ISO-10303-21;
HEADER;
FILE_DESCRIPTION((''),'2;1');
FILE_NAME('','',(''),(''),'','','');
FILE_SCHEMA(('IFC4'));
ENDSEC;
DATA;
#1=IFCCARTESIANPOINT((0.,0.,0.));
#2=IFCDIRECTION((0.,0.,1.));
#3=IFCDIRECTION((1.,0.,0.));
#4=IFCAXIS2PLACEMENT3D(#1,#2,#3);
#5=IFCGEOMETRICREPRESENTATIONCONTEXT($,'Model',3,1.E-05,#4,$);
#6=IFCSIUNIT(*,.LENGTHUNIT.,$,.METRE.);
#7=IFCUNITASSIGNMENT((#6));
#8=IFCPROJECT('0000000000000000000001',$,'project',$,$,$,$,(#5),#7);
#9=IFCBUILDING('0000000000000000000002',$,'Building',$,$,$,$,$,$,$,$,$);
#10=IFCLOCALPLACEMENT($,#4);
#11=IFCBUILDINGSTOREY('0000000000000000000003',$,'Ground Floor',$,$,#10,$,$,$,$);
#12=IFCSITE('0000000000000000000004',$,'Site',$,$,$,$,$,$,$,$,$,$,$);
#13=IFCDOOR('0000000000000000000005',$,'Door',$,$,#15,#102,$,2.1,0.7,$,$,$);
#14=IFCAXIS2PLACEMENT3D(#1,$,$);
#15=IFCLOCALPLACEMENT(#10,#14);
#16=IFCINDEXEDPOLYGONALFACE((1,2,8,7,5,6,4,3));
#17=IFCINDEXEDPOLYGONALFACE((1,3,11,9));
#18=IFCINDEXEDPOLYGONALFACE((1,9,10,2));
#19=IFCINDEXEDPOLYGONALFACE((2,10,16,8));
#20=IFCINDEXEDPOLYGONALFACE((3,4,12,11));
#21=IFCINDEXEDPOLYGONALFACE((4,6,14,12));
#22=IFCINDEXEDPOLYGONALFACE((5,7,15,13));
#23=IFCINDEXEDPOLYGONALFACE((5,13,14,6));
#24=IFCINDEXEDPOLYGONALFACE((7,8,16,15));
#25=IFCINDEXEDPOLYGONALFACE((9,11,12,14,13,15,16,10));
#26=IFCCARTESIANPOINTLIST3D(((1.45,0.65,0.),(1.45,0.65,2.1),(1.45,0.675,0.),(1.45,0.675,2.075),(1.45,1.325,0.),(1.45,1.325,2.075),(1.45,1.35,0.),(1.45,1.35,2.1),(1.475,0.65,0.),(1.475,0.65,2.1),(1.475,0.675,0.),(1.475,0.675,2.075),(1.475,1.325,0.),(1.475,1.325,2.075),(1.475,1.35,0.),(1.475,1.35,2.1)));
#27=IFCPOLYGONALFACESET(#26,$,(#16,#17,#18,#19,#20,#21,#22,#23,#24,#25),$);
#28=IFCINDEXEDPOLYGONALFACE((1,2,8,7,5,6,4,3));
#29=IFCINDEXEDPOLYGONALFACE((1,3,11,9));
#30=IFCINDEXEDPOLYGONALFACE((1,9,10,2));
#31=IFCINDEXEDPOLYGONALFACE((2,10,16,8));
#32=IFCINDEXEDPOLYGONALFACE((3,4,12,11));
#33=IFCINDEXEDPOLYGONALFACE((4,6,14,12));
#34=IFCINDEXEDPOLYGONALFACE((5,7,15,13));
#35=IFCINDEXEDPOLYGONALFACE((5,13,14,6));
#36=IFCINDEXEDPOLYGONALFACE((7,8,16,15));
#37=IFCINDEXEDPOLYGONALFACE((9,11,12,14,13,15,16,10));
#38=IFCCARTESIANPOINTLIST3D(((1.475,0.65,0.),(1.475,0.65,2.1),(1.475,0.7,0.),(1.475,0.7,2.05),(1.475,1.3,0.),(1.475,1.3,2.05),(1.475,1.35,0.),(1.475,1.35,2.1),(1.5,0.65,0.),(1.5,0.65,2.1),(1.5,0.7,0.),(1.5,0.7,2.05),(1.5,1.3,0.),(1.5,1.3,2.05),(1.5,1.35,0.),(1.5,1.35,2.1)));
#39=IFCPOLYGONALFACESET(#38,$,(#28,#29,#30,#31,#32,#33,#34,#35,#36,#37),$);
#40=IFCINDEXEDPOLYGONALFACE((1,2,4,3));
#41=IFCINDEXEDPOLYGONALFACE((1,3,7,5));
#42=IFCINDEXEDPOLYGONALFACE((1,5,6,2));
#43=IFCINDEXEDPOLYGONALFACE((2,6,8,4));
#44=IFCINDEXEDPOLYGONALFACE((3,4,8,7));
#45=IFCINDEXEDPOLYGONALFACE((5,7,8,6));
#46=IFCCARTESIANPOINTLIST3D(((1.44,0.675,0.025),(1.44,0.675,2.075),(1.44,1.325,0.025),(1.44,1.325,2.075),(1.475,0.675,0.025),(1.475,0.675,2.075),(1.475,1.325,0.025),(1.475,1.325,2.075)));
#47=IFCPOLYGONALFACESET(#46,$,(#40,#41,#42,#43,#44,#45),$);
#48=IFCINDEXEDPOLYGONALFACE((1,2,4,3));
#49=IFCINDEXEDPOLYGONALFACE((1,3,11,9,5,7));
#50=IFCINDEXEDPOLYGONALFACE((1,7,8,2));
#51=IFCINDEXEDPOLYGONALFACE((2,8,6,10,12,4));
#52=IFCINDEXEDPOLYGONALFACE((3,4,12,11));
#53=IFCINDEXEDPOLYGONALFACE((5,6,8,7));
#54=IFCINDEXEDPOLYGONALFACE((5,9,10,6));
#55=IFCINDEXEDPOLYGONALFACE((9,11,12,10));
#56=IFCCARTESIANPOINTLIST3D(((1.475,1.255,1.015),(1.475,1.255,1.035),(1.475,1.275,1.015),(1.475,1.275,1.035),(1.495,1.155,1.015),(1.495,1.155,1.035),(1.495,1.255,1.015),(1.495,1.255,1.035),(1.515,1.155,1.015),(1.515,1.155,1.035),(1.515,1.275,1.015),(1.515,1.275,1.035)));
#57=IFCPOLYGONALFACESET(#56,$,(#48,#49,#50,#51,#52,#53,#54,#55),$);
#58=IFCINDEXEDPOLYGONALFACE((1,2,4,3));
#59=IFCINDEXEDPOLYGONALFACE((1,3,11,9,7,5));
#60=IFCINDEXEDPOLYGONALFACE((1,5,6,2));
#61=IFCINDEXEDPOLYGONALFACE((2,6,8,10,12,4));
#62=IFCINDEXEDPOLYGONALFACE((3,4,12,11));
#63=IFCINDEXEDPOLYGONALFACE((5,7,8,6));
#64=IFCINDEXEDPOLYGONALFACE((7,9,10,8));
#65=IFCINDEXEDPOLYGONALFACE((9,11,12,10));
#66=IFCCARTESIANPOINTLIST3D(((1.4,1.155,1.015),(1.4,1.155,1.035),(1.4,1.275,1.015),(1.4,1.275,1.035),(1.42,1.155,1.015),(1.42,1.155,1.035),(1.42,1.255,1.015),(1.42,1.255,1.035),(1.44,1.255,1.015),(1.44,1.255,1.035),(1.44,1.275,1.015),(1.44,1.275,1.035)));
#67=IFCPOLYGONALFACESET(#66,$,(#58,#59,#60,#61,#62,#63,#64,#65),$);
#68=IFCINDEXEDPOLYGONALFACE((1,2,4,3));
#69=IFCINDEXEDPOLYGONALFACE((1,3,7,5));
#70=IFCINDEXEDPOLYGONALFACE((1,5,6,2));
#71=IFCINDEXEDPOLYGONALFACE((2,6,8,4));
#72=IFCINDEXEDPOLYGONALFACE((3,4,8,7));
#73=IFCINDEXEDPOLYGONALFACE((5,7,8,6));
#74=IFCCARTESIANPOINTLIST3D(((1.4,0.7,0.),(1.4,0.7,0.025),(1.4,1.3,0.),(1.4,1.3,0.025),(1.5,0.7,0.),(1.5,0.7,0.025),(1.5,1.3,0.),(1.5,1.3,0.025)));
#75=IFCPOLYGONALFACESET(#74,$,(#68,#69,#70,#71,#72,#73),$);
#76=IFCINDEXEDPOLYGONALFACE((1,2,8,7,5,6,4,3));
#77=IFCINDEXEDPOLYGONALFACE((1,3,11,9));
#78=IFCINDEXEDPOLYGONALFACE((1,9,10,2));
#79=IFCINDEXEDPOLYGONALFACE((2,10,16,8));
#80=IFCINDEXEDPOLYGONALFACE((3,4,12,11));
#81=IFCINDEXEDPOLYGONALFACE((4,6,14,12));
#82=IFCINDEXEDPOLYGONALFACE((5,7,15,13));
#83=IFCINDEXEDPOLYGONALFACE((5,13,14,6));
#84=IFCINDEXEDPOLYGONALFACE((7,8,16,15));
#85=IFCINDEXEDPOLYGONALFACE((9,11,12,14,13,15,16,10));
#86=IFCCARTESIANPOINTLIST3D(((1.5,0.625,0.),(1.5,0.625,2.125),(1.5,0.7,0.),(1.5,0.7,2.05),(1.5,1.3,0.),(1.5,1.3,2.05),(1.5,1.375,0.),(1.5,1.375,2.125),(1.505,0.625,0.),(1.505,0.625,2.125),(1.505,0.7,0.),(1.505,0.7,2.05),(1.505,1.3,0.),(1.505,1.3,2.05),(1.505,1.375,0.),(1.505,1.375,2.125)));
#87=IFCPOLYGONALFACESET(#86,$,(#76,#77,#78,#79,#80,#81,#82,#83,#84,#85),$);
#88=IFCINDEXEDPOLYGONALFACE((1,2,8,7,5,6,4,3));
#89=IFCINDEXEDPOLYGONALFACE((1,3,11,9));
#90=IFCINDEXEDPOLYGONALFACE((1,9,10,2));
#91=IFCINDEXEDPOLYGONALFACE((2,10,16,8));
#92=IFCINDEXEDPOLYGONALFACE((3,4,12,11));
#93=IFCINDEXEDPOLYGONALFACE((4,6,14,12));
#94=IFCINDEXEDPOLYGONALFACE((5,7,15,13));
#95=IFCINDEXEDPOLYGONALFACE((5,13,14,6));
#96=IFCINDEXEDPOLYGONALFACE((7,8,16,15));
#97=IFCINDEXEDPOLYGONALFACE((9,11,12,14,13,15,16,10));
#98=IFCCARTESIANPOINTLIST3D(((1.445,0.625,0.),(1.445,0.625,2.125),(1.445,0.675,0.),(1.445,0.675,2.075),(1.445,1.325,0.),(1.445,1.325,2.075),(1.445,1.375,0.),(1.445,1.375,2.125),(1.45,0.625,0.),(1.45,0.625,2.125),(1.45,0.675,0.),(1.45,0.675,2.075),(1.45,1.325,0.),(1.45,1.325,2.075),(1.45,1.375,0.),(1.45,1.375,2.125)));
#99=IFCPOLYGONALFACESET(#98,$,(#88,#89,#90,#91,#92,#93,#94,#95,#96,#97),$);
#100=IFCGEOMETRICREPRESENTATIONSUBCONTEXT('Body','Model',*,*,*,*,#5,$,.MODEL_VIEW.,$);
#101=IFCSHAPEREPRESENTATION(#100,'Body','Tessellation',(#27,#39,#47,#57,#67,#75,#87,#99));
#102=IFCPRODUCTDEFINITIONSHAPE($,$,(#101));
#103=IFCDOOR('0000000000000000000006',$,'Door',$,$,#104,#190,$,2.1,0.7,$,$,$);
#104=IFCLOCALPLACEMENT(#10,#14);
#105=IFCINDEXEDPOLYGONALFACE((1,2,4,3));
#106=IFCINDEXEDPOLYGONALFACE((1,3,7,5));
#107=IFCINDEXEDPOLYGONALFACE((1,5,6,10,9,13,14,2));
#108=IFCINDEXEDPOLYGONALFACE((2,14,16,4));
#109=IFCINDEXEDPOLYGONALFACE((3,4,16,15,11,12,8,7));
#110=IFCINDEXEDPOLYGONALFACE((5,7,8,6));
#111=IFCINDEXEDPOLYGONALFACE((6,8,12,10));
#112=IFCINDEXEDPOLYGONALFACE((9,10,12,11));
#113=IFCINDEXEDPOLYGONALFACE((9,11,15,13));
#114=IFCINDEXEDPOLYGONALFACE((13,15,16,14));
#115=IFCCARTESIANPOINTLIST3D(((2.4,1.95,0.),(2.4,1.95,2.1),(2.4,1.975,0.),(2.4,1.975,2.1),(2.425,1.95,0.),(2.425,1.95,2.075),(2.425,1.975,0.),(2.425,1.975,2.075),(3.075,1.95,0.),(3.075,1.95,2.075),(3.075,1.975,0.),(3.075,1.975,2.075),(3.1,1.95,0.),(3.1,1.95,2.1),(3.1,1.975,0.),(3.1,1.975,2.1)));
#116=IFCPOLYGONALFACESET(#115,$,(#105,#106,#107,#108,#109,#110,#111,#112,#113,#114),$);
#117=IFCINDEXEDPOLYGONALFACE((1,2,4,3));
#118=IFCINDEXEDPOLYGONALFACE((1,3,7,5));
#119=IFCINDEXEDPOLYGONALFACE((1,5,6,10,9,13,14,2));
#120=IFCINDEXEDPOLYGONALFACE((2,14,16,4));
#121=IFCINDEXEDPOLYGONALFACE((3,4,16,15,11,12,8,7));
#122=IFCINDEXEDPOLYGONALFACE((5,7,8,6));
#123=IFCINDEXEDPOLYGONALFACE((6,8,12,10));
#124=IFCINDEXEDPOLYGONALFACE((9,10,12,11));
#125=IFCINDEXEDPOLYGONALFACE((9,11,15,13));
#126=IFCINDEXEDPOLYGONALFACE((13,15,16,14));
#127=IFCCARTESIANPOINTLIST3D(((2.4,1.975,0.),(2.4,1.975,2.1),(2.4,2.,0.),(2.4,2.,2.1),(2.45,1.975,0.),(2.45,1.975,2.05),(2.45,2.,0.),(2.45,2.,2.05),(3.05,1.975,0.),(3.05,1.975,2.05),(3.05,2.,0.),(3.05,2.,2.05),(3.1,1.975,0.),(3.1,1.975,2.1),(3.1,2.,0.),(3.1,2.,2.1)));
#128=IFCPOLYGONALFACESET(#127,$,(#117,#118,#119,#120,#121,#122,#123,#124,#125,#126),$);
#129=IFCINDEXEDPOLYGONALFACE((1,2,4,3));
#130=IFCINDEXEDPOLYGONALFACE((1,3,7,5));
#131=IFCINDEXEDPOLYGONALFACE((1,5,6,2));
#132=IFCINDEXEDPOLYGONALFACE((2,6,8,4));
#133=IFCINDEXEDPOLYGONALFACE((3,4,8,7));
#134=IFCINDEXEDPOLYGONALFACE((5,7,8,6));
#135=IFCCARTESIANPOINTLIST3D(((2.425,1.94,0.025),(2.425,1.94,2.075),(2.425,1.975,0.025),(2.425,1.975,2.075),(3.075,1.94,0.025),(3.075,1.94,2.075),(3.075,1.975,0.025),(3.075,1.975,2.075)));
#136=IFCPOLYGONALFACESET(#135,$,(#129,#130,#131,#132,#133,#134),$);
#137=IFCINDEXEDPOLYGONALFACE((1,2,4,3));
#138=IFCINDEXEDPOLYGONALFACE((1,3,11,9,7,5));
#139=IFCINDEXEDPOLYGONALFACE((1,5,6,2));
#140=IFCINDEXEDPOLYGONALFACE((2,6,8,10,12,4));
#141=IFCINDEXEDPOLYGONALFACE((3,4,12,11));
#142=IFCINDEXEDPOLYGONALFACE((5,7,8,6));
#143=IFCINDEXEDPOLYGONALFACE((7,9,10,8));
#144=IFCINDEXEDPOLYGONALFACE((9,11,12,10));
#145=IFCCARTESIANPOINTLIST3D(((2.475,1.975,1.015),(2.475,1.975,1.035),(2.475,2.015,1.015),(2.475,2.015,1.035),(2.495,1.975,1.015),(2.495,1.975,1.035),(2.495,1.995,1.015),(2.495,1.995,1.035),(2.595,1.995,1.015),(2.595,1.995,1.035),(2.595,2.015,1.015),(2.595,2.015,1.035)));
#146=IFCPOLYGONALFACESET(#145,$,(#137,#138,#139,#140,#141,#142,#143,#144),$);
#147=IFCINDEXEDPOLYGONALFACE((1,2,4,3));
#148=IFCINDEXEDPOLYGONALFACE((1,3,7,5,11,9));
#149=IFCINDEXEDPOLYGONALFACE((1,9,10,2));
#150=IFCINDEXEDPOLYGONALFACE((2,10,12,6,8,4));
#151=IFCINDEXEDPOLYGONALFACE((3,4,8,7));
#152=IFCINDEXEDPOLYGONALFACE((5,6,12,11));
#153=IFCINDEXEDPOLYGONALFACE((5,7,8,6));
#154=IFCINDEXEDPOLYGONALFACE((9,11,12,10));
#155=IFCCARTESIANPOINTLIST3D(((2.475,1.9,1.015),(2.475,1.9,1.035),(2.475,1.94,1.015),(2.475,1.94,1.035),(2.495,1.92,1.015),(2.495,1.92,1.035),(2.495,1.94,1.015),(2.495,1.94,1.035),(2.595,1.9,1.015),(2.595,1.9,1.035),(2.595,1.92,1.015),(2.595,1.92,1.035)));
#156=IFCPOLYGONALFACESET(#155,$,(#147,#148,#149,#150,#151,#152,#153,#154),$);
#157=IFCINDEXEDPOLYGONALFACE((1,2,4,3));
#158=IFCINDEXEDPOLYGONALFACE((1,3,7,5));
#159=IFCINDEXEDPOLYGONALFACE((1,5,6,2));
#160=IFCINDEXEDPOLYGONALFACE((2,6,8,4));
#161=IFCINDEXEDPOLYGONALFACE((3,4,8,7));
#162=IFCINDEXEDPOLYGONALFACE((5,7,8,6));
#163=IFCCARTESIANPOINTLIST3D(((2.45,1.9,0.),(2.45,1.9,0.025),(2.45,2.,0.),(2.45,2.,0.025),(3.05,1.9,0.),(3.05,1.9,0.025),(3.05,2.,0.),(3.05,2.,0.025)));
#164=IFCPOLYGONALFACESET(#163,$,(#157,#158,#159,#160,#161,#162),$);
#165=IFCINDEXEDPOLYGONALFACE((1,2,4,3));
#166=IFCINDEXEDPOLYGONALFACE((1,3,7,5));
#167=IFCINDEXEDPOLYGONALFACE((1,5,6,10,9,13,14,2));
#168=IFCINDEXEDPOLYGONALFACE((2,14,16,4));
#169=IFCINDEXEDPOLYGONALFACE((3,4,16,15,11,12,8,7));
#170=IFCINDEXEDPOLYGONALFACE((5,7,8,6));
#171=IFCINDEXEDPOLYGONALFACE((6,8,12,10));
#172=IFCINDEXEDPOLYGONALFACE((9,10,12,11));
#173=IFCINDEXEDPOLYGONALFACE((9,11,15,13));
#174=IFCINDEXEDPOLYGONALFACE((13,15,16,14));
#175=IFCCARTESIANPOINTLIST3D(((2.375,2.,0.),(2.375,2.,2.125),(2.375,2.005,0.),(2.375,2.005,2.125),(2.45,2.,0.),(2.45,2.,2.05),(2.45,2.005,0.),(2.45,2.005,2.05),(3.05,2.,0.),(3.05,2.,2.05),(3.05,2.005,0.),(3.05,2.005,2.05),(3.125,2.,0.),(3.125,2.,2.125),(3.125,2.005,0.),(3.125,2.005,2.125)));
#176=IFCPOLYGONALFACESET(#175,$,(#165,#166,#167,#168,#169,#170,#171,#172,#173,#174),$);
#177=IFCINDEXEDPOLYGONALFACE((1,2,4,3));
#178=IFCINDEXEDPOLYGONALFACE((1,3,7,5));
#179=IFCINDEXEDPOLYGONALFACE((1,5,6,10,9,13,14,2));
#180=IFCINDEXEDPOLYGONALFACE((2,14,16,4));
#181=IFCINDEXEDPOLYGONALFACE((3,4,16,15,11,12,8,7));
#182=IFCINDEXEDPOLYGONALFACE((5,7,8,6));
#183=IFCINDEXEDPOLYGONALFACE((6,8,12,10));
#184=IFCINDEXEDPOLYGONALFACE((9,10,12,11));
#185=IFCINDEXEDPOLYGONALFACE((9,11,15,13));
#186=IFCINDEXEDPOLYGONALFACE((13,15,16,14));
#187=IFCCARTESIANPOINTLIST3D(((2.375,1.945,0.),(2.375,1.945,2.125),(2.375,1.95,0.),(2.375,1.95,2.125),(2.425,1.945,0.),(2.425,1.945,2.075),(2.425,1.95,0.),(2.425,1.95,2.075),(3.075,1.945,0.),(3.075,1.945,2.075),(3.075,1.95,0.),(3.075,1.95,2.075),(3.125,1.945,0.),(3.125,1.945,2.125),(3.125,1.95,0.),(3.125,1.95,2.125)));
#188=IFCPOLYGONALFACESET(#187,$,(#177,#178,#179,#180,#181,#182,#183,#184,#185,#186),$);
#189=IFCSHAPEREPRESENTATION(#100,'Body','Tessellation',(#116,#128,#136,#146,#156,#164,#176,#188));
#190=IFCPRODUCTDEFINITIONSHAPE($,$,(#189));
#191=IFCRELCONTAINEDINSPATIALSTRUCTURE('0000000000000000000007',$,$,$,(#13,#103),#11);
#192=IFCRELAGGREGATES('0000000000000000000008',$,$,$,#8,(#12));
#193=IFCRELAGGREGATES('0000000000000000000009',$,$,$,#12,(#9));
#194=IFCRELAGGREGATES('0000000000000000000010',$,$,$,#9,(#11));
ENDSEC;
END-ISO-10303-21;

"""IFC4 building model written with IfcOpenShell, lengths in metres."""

from ifc_helpers import new_model, si_unit, frame, origin_with_axes, place, context, subcontext, project, spatial, line, indexed_curve, outline, extrude, element, save


model = new_model("IFC4")

# Units and contexts
model_context = context("Model", 3, precision=1e-05, world=origin_with_axes())
body_context = subcontext(model_context, "Body", "Model", "MODEL_VIEW")
ifc_project = project(units=[si_unit("LENGTHUNIT", "METRE")], contexts=[model_context])

# Site, building, storey
site = spatial("IfcSite", under=ifc_project, Name="Site")
building = spatial("IfcBuilding", under=site, Name="Building")
storey_placement = place(None, origin_with_axes())
storey = spatial("IfcBuildingStorey", under=building, at=storey_placement, Name="Ground Floor")

# Doors
door_1_placement = place(storey_placement, frame((1.5, 0.65, 0.0), z_axis=(0.0, 0.0, 1.0), x_axis=(0.0, 1.0, 0.0)))
element("IfcDoor", 1, at=door_1_placement, inside=storey, Name="Door", OverallHeight=2.1, OverallWidth=0.7, context=body_context, shape_type="SweptSolid", body=[
    extrude(outline(indexed_curve([(0.0, 0.0), (0.0, 2.1), (0.7, 2.1), (0.7, 0.0), (0.675, 0.0), (0.675, 2.075), (0.025, 2.075), (0.025, 0.0)], segments=[line(1, 2, 3, 4, 5, 6, 7, 8, 1)])), frame((0.0, 0.025, 0.0), z_axis=(0.0, -1.0, 0.0), x_axis=(1.0, 0.0, 0.0)), (0.0, 0.0, -1.0), 0.025),
    extrude(outline(indexed_curve([(0.0, 0.0), (0.0, 2.1), (0.7, 2.1), (0.7, 0.0), (0.65, 0.0), (0.65, 2.05), (0.05, 2.05), (0.05, 0.0)], segments=[line(1, 2, 3, 4, 5, 6, 7, 8, 1)])), frame((0.0, 0.0, 0.0), z_axis=(0.0, -1.0, 0.0), x_axis=(1.0, 0.0, 0.0)), (0.0, 0.0, -1.0), 0.025),
    extrude(outline(indexed_curve([(0.0, 0.0), (0.65, 0.0), (0.65, 0.035), (0.0, 0.035)], segments=[line(1, 2, 3, 4, 1)])), frame((0.025, 0.025, 0.025), z_axis=(0.0, 0.0, 1.0), x_axis=(1.0, 0.0, 0.0)), (0.0, 0.0, 1.0), 2.05),
    extrude(outline(indexed_curve([(0.0, 0.0), (0.0, -0.04), (-0.12, -0.04), (-0.12, -0.02), (-0.02, -0.02), (-0.02, 0.0)], segments=[line(1, 2, 3, 4, 5, 6, 1)])), frame((0.625, 0.025, 1.015), z_axis=(0.0, 0.0, 1.0), x_axis=(1.0, 0.0, 0.0)), (0.0, 0.0, 1.0), 0.02),
    extrude(outline(indexed_curve([(0.0, 0.0), (0.0, 0.04), (-0.12, 0.04), (-0.12, 0.02), (-0.02, 0.02), (-0.02, 0.0)], segments=[line(1, 2, 3, 4, 5, 6, 1)])), frame((0.625, 0.06, 1.015), z_axis=(0.0, 0.0, 1.0), x_axis=(1.0, 0.0, 0.0)), (0.0, 0.0, 1.0), 0.02),
    extrude(outline(indexed_curve([(0.0, 0.0), (0.6, 0.0), (0.6, 0.1), (0.0, 0.1)], segments=[line(1, 2, 3, 4, 1)])), frame((0.05, 0.0, 0.0), z_axis=(0.0, 0.0, 1.0), x_axis=(1.0, 0.0, 0.0)), (0.0, 0.0, 1.0), 0.025),
    extrude(outline(indexed_curve([(0.0, 0.0), (0.0, 2.125), (0.75, 2.125), (0.75, 0.0), (0.675, 0.0), (0.675, 2.05), (0.075, 2.05), (0.075, 0.0)], segments=[line(1, 2, 3, 4, 5, 6, 7, 8, 1)])), frame((-0.025, -0.005, 0.0), z_axis=(0.0, -1.0, 0.0), x_axis=(1.0, 0.0, 0.0)), (0.0, 0.0, -1.0), 0.005),
    extrude(outline(indexed_curve([(0.0, 0.0), (0.0, 2.125), (0.75, 2.125), (0.75, 0.0), (0.7, 0.0), (0.7, 2.075), (0.05, 2.075), (0.05, 0.0)], segments=[line(1, 2, 3, 4, 5, 6, 7, 8, 1)])), frame((-0.025, 0.05, 0.0), z_axis=(0.0, -1.0, 0.0), x_axis=(1.0, 0.0, 0.0)), (0.0, 0.0, -1.0), 0.005),
])
door_2_placement = place(storey_placement, frame((3.1, 2.0, 0.0), z_axis=(0.0, 0.0, 1.0), x_axis=(-1.0, 0.0, 0.0)))
element("IfcDoor", 2, at=door_2_placement, inside=storey, Name="Door", OverallHeight=2.1, OverallWidth=0.7, context=body_context, shape_type="SweptSolid", body=[
    extrude(outline(indexed_curve([(0.0, 0.0), (0.0, 2.1), (0.7, 2.1), (0.7, 0.0), (0.675, 0.0), (0.675, 2.075), (0.025, 2.075), (0.025, 0.0)], segments=[line(1, 2, 3, 4, 5, 6, 7, 8, 1)])), frame((0.0, 0.025, 0.0), z_axis=(0.0, -1.0, 0.0), x_axis=(1.0, 0.0, 0.0)), (0.0, 0.0, -1.0), 0.025),
    extrude(outline(indexed_curve([(0.0, 0.0), (0.0, 2.1), (0.7, 2.1), (0.7, 0.0), (0.65, 0.0), (0.65, 2.05), (0.05, 2.05), (0.05, 0.0)], segments=[line(1, 2, 3, 4, 5, 6, 7, 8, 1)])), frame((0.0, 0.0, 0.0), z_axis=(0.0, -1.0, 0.0), x_axis=(1.0, 0.0, 0.0)), (0.0, 0.0, -1.0), 0.025),
    extrude(outline(indexed_curve([(0.0, 0.0), (0.65, 0.0), (0.65, 0.035), (0.0, 0.035)], segments=[line(1, 2, 3, 4, 1)])), frame((0.025, 0.025, 0.025), z_axis=(0.0, 0.0, 1.0), x_axis=(1.0, 0.0, 0.0)), (0.0, 0.0, 1.0), 2.05),
    extrude(outline(indexed_curve([(0.0, 0.0), (0.0, -0.04), (-0.12, -0.04), (-0.12, -0.02), (-0.02, -0.02), (-0.02, 0.0)], segments=[line(1, 2, 3, 4, 5, 6, 1)])), frame((0.625, 0.025, 1.015), z_axis=(0.0, 0.0, 1.0), x_axis=(1.0, 0.0, 0.0)), (0.0, 0.0, 1.0), 0.02),
    extrude(outline(indexed_curve([(0.0, 0.0), (0.0, 0.04), (-0.12, 0.04), (-0.12, 0.02), (-0.02, 0.02), (-0.02, 0.0)], segments=[line(1, 2, 3, 4, 5, 6, 1)])), frame((0.625, 0.06, 1.015), z_axis=(0.0, 0.0, 1.0), x_axis=(1.0, 0.0, 0.0)), (0.0, 0.0, 1.0), 0.02),
    extrude(outline(indexed_curve([(0.0, 0.0), (0.6, 0.0), (0.6, 0.1), (0.0, 0.1)], segments=[line(1, 2, 3, 4, 1)])), frame((0.05, 0.0, 0.0), z_axis=(0.0, 0.0, 1.0), x_axis=(1.0, 0.0, 0.0)), (0.0, 0.0, 1.0), 0.025),
    extrude(outline(indexed_curve([(0.0, 0.0), (0.0, 2.125), (0.75, 2.125), (0.75, 0.0), (0.675, 0.0), (0.675, 2.05), (0.075, 2.05), (0.075, 0.0)], segments=[line(1, 2, 3, 4, 5, 6, 7, 8, 1)])), frame((-0.025, -0.005, 0.0), z_axis=(0.0, -1.0, 0.0), x_axis=(1.0, 0.0, 0.0)), (0.0, 0.0, -1.0), 0.005),
    extrude(outline(indexed_curve([(0.0, 0.0), (0.0, 2.125), (0.75, 2.125), (0.75, 0.0), (0.7, 0.0), (0.7, 2.075), (0.05, 2.075), (0.05, 0.0)], segments=[line(1, 2, 3, 4, 5, 6, 7, 8, 1)])), frame((-0.025, 0.05, 0.0), z_axis=(0.0, -1.0, 0.0), x_axis=(1.0, 0.0, 0.0)), (0.0, 0.0, -1.0), 0.005),
])

save(model, "model.ifc")
